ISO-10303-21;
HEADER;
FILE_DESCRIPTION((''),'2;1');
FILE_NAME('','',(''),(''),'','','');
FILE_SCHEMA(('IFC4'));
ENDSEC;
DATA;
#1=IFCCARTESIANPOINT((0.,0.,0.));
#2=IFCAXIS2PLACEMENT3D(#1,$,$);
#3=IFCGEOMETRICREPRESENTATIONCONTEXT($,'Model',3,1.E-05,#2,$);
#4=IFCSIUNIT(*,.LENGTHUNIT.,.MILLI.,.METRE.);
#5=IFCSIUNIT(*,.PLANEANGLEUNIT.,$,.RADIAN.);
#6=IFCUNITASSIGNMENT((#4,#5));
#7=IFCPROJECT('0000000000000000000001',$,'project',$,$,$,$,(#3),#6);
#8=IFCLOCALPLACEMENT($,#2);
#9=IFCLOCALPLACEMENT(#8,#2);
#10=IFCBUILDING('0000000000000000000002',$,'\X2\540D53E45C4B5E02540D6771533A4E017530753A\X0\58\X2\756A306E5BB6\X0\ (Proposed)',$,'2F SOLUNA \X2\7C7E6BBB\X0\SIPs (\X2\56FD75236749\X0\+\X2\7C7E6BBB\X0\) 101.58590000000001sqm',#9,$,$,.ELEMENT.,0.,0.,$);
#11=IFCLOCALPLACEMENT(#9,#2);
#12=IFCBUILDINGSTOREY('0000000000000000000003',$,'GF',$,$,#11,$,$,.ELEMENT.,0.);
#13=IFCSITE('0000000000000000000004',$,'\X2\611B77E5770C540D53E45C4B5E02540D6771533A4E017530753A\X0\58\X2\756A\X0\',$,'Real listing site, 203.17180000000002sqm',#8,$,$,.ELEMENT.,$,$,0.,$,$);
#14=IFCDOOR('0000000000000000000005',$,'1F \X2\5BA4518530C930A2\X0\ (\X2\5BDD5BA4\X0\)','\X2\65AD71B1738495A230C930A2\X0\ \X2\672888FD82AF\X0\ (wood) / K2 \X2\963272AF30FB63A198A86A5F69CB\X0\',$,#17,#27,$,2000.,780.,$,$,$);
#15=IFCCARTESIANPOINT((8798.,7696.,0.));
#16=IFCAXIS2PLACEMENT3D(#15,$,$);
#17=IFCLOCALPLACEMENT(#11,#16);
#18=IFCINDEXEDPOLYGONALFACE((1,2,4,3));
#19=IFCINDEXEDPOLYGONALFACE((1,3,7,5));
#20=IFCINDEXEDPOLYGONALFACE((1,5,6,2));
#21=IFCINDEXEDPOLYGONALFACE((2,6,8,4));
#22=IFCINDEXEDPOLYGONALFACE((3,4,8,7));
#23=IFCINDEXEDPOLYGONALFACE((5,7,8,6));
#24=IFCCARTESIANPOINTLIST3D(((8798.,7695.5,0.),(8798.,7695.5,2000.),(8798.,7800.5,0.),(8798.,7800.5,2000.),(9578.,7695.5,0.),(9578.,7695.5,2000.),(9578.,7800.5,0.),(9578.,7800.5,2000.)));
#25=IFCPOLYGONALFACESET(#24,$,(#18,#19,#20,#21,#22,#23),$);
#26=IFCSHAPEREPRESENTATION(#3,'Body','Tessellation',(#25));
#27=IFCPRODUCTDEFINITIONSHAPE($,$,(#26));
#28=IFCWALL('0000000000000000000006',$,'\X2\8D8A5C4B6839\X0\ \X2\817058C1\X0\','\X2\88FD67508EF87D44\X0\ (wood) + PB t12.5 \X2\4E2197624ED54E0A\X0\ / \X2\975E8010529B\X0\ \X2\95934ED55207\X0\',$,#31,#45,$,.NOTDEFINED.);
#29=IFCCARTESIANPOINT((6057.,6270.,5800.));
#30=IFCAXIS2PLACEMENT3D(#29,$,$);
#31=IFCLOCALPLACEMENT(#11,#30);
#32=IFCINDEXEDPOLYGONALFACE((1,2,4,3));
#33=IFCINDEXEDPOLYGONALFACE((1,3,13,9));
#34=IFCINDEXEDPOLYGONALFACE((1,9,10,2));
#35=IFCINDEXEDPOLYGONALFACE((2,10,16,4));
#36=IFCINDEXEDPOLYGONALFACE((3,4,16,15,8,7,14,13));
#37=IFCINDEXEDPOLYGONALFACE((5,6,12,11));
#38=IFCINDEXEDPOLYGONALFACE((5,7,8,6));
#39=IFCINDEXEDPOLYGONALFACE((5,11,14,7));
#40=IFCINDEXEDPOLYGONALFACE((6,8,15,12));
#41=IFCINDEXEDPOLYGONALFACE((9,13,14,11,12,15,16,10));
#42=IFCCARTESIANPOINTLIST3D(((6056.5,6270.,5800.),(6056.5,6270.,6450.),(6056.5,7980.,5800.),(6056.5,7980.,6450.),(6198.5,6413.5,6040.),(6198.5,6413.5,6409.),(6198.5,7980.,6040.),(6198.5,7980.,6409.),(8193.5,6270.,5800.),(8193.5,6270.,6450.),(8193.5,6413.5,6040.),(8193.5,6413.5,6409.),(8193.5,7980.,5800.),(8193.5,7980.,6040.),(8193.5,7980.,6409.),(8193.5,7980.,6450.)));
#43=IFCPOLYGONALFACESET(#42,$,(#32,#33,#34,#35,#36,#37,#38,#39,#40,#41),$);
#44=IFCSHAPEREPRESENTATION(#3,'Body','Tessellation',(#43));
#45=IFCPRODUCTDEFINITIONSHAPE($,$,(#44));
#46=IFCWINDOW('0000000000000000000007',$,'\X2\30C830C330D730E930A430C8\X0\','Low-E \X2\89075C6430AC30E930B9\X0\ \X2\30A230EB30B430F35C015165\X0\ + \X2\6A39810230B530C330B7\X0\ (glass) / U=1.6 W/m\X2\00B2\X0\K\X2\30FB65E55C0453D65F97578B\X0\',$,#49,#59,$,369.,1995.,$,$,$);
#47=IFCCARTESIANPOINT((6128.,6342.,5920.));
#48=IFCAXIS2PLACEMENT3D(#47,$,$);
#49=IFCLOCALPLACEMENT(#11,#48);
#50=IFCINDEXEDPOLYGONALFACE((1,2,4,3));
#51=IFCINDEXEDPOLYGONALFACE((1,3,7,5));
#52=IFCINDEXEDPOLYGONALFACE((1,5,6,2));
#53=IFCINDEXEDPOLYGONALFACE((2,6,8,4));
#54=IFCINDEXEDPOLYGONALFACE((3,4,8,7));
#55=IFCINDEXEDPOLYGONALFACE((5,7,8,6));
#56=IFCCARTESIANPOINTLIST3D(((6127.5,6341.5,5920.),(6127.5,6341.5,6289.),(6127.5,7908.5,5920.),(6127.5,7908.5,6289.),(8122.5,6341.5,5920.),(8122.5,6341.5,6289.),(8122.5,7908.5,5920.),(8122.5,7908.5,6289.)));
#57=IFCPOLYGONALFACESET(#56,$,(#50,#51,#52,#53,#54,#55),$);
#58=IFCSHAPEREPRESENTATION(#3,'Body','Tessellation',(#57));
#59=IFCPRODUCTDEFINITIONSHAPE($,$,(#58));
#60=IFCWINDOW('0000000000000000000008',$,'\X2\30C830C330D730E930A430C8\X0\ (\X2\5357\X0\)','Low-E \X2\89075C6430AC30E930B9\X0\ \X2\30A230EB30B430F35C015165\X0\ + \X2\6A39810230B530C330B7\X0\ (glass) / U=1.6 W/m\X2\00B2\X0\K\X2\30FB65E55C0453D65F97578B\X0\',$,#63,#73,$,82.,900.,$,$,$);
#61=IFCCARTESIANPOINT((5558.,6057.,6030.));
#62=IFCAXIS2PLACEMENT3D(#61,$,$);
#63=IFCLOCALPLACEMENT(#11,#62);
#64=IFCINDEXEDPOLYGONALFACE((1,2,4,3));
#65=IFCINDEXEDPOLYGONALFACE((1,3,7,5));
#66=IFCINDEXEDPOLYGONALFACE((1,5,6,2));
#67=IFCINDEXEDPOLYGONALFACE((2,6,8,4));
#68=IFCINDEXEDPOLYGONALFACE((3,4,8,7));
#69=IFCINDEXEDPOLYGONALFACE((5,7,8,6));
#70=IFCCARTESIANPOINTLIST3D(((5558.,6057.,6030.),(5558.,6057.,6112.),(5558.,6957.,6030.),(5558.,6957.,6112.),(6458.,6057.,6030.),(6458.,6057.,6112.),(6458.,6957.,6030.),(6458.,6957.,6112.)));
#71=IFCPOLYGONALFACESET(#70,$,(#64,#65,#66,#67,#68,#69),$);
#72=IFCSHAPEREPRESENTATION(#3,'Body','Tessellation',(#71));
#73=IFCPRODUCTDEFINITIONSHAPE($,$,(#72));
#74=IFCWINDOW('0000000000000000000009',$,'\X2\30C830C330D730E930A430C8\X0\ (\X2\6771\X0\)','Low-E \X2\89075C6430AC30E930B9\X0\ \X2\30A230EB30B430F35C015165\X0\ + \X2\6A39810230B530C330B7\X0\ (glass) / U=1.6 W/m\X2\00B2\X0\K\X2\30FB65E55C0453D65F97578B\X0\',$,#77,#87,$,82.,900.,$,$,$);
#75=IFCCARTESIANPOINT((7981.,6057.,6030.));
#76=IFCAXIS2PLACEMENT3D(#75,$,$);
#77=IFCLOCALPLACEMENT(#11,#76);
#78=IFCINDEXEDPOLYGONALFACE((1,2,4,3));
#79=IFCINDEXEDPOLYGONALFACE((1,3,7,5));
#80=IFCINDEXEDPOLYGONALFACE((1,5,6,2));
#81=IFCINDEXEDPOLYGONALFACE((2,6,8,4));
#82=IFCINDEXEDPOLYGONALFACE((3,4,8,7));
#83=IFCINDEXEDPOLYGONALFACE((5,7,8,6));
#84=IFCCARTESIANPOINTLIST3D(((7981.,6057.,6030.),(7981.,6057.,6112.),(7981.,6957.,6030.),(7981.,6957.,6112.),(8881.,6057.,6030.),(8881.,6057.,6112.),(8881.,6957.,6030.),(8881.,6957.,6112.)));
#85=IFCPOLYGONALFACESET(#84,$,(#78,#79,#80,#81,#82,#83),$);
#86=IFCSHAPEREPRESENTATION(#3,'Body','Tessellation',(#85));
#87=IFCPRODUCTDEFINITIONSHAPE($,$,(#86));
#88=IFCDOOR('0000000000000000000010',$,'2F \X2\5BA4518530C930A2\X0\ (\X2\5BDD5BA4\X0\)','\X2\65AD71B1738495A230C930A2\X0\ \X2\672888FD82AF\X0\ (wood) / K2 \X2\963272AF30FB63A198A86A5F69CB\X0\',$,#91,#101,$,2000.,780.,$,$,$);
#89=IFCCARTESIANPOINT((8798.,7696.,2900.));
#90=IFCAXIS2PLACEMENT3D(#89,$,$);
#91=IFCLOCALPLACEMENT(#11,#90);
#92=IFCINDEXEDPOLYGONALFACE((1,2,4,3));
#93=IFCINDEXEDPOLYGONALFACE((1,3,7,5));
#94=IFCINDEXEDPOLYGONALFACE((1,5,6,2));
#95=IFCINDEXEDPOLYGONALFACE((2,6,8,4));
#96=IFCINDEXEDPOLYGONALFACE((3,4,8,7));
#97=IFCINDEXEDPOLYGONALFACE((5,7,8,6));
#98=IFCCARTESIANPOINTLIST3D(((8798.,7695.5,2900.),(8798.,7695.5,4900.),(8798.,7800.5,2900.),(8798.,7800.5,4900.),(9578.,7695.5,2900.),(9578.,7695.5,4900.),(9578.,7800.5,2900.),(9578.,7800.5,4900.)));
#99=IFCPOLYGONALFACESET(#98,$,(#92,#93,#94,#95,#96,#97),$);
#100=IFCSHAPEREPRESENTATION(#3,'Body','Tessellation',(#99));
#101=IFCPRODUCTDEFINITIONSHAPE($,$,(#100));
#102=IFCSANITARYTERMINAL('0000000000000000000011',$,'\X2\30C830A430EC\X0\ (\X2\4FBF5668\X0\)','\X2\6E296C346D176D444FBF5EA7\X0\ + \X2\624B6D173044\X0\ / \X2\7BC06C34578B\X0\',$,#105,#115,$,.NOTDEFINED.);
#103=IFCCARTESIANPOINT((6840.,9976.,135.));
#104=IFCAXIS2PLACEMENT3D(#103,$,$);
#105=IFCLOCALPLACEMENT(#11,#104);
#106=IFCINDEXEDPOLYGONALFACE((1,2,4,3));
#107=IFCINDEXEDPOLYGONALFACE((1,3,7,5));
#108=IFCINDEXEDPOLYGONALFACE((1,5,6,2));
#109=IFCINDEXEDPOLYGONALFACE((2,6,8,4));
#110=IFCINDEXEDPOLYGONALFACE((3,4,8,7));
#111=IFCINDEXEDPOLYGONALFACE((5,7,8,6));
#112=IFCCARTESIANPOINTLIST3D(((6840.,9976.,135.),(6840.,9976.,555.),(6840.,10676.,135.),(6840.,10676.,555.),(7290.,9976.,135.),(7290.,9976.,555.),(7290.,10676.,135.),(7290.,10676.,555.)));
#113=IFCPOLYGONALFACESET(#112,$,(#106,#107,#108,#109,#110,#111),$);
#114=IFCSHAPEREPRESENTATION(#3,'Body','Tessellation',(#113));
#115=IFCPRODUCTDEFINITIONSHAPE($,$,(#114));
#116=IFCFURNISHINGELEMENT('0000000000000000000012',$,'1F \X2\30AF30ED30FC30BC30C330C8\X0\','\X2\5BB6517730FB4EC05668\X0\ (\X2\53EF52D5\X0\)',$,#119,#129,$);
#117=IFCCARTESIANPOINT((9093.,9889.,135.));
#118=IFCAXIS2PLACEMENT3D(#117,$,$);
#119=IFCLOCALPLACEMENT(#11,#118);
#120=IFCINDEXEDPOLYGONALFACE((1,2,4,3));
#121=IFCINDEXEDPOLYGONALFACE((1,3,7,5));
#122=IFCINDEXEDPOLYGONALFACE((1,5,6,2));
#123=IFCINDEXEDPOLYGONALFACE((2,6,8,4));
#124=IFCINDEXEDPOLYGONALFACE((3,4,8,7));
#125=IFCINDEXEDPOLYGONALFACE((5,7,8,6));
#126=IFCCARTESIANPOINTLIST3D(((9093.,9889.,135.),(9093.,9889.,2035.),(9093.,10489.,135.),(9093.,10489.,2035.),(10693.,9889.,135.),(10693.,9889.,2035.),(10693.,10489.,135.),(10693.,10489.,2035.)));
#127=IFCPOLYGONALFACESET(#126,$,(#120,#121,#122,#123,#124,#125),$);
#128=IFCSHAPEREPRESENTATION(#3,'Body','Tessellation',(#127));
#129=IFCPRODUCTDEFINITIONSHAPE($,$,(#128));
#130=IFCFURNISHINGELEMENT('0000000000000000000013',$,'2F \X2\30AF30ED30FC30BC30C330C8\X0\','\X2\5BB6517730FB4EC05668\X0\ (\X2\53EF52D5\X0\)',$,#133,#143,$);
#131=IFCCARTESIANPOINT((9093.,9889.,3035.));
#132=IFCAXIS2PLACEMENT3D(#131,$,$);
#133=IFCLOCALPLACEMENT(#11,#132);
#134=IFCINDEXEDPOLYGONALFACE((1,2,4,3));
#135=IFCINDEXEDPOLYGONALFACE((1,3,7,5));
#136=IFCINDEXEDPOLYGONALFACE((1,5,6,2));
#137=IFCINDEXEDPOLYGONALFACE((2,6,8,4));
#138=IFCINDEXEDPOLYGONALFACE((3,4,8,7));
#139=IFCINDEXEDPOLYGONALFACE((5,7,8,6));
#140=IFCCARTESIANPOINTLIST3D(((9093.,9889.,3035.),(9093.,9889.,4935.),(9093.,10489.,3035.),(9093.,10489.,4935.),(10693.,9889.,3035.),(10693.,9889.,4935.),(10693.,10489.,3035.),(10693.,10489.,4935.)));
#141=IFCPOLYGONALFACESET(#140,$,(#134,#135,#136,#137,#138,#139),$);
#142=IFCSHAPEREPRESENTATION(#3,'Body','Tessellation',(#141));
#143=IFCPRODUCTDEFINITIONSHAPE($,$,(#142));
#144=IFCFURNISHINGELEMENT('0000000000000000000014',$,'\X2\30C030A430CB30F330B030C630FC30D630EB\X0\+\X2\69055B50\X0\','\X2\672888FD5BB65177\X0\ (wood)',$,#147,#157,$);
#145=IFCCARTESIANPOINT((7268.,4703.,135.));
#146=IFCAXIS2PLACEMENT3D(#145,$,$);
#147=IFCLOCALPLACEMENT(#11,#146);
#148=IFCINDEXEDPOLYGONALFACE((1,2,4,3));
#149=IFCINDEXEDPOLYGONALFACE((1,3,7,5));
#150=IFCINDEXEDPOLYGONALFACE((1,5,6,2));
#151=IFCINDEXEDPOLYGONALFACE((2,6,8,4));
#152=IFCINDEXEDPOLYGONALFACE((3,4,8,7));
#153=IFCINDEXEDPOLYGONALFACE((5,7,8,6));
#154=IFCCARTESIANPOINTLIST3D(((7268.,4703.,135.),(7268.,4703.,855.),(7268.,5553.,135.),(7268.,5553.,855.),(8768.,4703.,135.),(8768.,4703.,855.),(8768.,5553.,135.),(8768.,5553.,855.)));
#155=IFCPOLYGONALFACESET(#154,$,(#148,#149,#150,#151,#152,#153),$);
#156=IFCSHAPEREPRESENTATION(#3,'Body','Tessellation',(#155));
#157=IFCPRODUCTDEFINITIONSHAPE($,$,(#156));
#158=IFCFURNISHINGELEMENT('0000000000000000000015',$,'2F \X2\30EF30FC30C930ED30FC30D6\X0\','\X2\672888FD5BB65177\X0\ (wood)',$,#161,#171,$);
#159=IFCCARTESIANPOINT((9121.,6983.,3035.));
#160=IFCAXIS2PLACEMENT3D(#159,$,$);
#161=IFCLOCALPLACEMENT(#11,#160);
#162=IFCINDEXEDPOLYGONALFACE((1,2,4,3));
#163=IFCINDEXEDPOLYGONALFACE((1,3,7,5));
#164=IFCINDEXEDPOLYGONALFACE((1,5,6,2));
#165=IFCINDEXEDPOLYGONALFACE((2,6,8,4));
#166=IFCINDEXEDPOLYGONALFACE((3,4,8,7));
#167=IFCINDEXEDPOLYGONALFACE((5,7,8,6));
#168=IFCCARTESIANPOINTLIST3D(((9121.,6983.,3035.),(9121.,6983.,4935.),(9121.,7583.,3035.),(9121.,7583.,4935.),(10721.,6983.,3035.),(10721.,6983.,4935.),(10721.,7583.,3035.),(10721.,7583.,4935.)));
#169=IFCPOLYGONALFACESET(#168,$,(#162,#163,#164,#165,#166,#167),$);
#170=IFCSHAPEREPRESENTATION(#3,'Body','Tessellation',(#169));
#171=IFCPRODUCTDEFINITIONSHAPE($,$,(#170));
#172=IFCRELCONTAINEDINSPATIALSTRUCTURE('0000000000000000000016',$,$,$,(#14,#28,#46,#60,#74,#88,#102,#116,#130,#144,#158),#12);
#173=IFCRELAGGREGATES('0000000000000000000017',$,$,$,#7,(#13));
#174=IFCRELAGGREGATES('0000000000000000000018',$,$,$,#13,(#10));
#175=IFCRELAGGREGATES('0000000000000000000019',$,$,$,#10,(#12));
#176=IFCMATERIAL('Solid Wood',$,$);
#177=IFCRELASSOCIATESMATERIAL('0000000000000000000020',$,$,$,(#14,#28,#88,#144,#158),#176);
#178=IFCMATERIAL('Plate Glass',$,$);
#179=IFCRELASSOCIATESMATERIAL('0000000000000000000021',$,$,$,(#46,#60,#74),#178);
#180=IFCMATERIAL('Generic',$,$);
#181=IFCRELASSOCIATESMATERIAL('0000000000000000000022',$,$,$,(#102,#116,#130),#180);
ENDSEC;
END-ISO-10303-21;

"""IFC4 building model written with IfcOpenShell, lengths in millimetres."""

from ifc_helpers import new_model, si_unit, frame, frame_2d, origin, place, context, project, spatial, rectangle, extrude, material, element, fill, save


model = new_model("IFC4")

# Units and contexts
model_context = context("Model", 3, precision=1e-05, world=origin())
ifc_project = project(units=[si_unit("LENGTHUNIT", "METRE", prefix="MILLI"), si_unit("PLANEANGLEUNIT", "RADIAN")], contexts=[model_context])

# Site, building, storey
site_placement = place(None, origin())
site = spatial("IfcSite", under=ifc_project, at=site_placement, Name="愛知県名古屋市名東区丁田町58番", ObjectType="Real listing site, 203.17180000000002sqm", CompositionType="ELEMENT", RefElevation=0.0)
building_placement = place(site_placement, origin())
building = spatial("IfcBuilding", under=site, at=building_placement, Name="名古屋市名東区丁田町58番の家 (Proposed)", ObjectType="2F SOLUNA 籾殻SIPs (国産杉+籾殻) 101.58590000000001sqm", CompositionType="ELEMENT", ElevationOfRefHeight=0.0, ElevationOfTerrain=0.0)
storey_placement = place(building_placement, origin())
storey = spatial("IfcBuildingStorey", under=building, at=storey_placement, Name="GF", CompositionType="ELEMENT", Elevation=0.0)

# Shared definitions
ifc_material_1 = material(Name="Solid Wood")

# Door
door_1_placement = place(storey_placement, frame((8798.0, 7696.0, 0.0)))
element("IfcDoor", 1, at=door_1_placement, inside=storey, material=ifc_material_1, Name="1F 室内ドア (寝室)", Description="断熱玄関ドア 木製芯 (wood) / K2 防犯・採風機構", OverallHeight=2000.0, OverallWidth=780.0, context=model_context, shape_type="SweptSolid", body=[
    extrude(rectangle(XDim=780.0, YDim=105.0, at=frame_2d((390.0, 52.0))), frame((8798.0, 7696.0, 0.0)), (0.0, 0.0, 1.0), 2000.0),
])

# Wall, openings, windows
wall_1_placement = place(storey_placement, frame((6057.0, 6270.0, 5800.0)))
wall_1 = element("IfcWall", 2, at=wall_1_placement, inside=storey, material=ifc_material_1, Name="越屋根 腰壁", Description="製材軸組 (wood) + PB t12.5 両面仕上 / 非耐力 間仕切", PredefinedType="NOTDEFINED", context=model_context, shape_type="SweptSolid", body=[
    extrude(rectangle(XDim=2137.0, YDim=1710.0, at=frame_2d((1068.0, 855.0))), frame((6057.0, 6270.0, 5800.0)), (0.0, 0.0, 1.0), 650.0),
])
opening_1_placement = place(storey_placement, frame((6128.0, 6342.0, 5920.0)))
opening_1 = element("IfcOpeningElement", 3, at=opening_1_placement, cuts=wall_1, PredefinedType="NOTDEFINED", context=model_context, shape_type="SweptSolid", body=[
    extrude(rectangle(XDim=1995.0, YDim=1567.0, at=frame_2d((997.0, 783.0))), frame((6128.0, 6342.0, 5920.0)), (0.0, 0.0, 1.0), 369.0),
])
opening_2_placement = place(storey_placement, frame((5558.0, 6057.0, 6030.0)))
opening_2 = element("IfcOpeningElement", 4, at=opening_2_placement, cuts=wall_1, PredefinedType="NOTDEFINED", context=model_context, shape_type="SweptSolid", body=[
    extrude(rectangle(XDim=900.0, YDim=900.0, at=frame_2d((450.0, 450.0))), frame((5558.0, 6057.0, 6030.0)), (0.0, 0.0, 1.0), 82.0),
])
opening_3_placement = place(storey_placement, frame((7981.0, 6057.0, 6030.0)))
opening_3 = element("IfcOpeningElement", 5, at=opening_3_placement, cuts=wall_1, PredefinedType="NOTDEFINED", context=model_context, shape_type="SweptSolid", body=[
    extrude(rectangle(XDim=900.0, YDim=900.0, at=frame_2d((450.0, 450.0))), frame((7981.0, 6057.0, 6030.0)), (0.0, 0.0, 1.0), 82.0),
])
ifc_material_2 = material(Name="Plate Glass")
window_1_placement = place(storey_placement, frame((6128.0, 6342.0, 5920.0)))
window_1 = element("IfcWindow", 6, at=window_1_placement, inside=storey, material=ifc_material_2, Name="トップライト", Description="Low-E 複層ガラス アルゴン封入 + 樹脂サッシ (glass) / U=1.6 W/m²K・日射取得型", OverallHeight=369.0, OverallWidth=1995.0, context=model_context, shape_type="SweptSolid", body=[
    extrude(rectangle(XDim=1995.0, YDim=1567.0, at=frame_2d((997.0, 783.0))), frame((6128.0, 6342.0, 5920.0)), (0.0, 0.0, 1.0), 369.0),
])
fill(opening_1, window_1)
window_2_placement = place(storey_placement, frame((5558.0, 6057.0, 6030.0)))
window_2 = element("IfcWindow", 7, at=window_2_placement, inside=storey, material=ifc_material_2, Name="トップライト (南)", Description="Low-E 複層ガラス アルゴン封入 + 樹脂サッシ (glass) / U=1.6 W/m²K・日射取得型", OverallHeight=82.0, OverallWidth=900.0, context=model_context, shape_type="SweptSolid", body=[
    extrude(rectangle(XDim=900.0, YDim=900.0, at=frame_2d((450.0, 450.0))), frame((5558.0, 6057.0, 6030.0)), (0.0, 0.0, 1.0), 82.0),
])
fill(opening_2, window_2)
window_3_placement = place(storey_placement, frame((7981.0, 6057.0, 6030.0)))
window_3 = element("IfcWindow", 8, at=window_3_placement, inside=storey, material=ifc_material_2, Name="トップライト (東)", Description="Low-E 複層ガラス アルゴン封入 + 樹脂サッシ (glass) / U=1.6 W/m²K・日射取得型", OverallHeight=82.0, OverallWidth=900.0, context=model_context, shape_type="SweptSolid", body=[
    extrude(rectangle(XDim=900.0, YDim=900.0, at=frame_2d((450.0, 450.0))), frame((7981.0, 6057.0, 6030.0)), (0.0, 0.0, 1.0), 82.0),
])
fill(opening_3, window_3)

# Door
door_2_placement = place(storey_placement, frame((8798.0, 7696.0, 2900.0)))
element("IfcDoor", 9, at=door_2_placement, inside=storey, material=ifc_material_1, Name="2F 室内ドア (寝室)", Description="断熱玄関ドア 木製芯 (wood) / K2 防犯・採風機構", OverallHeight=2000.0, OverallWidth=780.0, context=model_context, shape_type="SweptSolid", body=[
    extrude(rectangle(XDim=780.0, YDim=105.0, at=frame_2d((390.0, 52.0))), frame((8798.0, 7696.0, 2900.0)), (0.0, 0.0, 1.0), 2000.0),
])

# Sanitary terminal
ifc_material_3 = material(Name="Generic")
sanitary_terminal_placement = place(storey_placement, frame((6840.0, 9976.0, 135.0)))
element("IfcSanitaryTerminal", 10, at=sanitary_terminal_placement, inside=storey, material=ifc_material_3, Name="トイレ (便器)", Description="温水洗浄便座 + 手洗い / 節水型", PredefinedType="NOTDEFINED", context=model_context, shape_type="SweptSolid", body=[
    extrude(rectangle(XDim=450.0, YDim=700.0, at=frame_2d((225.0, 350.0))), frame((6840.0, 9976.0, 135.0)), (0.0, 0.0, 1.0), 420.0),
])

# Furnishing elements
furnishing_1_placement = place(storey_placement, frame((9093.0, 9889.0, 135.0)))
element("IfcFurnishingElement", 11, at=furnishing_1_placement, inside=storey, material=ifc_material_3, Name="1F クローゼット", Description="家具・什器 (可動)", context=model_context, shape_type="SweptSolid", body=[
    extrude(rectangle(XDim=1600.0, YDim=600.0, at=frame_2d((800.0, 300.0))), frame((9093.0, 9889.0, 135.0)), (0.0, 0.0, 1.0), 1900.0),
])
furnishing_2_placement = place(storey_placement, frame((9093.0, 9889.0, 3035.0)))
element("IfcFurnishingElement", 12, at=furnishing_2_placement, inside=storey, material=ifc_material_3, Name="2F クローゼット", Description="家具・什器 (可動)", context=model_context, shape_type="SweptSolid", body=[
    extrude(rectangle(XDim=1600.0, YDim=600.0, at=frame_2d((800.0, 300.0))), frame((9093.0, 9889.0, 3035.0)), (0.0, 0.0, 1.0), 1900.0),
])
furnishing_3_placement = place(storey_placement, frame((7268.0, 4703.0, 135.0)))
element("IfcFurnishingElement", 13, at=furnishing_3_placement, inside=storey, material=ifc_material_1, Name="ダイニングテーブル+椅子", Description="木製家具 (wood)", context=model_context, shape_type="SweptSolid", body=[
    extrude(rectangle(XDim=1500.0, YDim=850.0, at=frame_2d((750.0, 425.0))), frame((7268.0, 4703.0, 135.0)), (0.0, 0.0, 1.0), 720.0),
])
furnishing_4_placement = place(storey_placement, frame((9121.0, 6983.0, 3035.0)))
element("IfcFurnishingElement", 14, at=furnishing_4_placement, inside=storey, material=ifc_material_1, Name="2F ワードローブ", Description="木製家具 (wood)", context=model_context, shape_type="SweptSolid", body=[
    extrude(rectangle(XDim=1600.0, YDim=600.0, at=frame_2d((800.0, 300.0))), frame((9121.0, 6983.0, 3035.0)), (0.0, 0.0, 1.0), 1900.0),
])

save(model, "model.ifc")
